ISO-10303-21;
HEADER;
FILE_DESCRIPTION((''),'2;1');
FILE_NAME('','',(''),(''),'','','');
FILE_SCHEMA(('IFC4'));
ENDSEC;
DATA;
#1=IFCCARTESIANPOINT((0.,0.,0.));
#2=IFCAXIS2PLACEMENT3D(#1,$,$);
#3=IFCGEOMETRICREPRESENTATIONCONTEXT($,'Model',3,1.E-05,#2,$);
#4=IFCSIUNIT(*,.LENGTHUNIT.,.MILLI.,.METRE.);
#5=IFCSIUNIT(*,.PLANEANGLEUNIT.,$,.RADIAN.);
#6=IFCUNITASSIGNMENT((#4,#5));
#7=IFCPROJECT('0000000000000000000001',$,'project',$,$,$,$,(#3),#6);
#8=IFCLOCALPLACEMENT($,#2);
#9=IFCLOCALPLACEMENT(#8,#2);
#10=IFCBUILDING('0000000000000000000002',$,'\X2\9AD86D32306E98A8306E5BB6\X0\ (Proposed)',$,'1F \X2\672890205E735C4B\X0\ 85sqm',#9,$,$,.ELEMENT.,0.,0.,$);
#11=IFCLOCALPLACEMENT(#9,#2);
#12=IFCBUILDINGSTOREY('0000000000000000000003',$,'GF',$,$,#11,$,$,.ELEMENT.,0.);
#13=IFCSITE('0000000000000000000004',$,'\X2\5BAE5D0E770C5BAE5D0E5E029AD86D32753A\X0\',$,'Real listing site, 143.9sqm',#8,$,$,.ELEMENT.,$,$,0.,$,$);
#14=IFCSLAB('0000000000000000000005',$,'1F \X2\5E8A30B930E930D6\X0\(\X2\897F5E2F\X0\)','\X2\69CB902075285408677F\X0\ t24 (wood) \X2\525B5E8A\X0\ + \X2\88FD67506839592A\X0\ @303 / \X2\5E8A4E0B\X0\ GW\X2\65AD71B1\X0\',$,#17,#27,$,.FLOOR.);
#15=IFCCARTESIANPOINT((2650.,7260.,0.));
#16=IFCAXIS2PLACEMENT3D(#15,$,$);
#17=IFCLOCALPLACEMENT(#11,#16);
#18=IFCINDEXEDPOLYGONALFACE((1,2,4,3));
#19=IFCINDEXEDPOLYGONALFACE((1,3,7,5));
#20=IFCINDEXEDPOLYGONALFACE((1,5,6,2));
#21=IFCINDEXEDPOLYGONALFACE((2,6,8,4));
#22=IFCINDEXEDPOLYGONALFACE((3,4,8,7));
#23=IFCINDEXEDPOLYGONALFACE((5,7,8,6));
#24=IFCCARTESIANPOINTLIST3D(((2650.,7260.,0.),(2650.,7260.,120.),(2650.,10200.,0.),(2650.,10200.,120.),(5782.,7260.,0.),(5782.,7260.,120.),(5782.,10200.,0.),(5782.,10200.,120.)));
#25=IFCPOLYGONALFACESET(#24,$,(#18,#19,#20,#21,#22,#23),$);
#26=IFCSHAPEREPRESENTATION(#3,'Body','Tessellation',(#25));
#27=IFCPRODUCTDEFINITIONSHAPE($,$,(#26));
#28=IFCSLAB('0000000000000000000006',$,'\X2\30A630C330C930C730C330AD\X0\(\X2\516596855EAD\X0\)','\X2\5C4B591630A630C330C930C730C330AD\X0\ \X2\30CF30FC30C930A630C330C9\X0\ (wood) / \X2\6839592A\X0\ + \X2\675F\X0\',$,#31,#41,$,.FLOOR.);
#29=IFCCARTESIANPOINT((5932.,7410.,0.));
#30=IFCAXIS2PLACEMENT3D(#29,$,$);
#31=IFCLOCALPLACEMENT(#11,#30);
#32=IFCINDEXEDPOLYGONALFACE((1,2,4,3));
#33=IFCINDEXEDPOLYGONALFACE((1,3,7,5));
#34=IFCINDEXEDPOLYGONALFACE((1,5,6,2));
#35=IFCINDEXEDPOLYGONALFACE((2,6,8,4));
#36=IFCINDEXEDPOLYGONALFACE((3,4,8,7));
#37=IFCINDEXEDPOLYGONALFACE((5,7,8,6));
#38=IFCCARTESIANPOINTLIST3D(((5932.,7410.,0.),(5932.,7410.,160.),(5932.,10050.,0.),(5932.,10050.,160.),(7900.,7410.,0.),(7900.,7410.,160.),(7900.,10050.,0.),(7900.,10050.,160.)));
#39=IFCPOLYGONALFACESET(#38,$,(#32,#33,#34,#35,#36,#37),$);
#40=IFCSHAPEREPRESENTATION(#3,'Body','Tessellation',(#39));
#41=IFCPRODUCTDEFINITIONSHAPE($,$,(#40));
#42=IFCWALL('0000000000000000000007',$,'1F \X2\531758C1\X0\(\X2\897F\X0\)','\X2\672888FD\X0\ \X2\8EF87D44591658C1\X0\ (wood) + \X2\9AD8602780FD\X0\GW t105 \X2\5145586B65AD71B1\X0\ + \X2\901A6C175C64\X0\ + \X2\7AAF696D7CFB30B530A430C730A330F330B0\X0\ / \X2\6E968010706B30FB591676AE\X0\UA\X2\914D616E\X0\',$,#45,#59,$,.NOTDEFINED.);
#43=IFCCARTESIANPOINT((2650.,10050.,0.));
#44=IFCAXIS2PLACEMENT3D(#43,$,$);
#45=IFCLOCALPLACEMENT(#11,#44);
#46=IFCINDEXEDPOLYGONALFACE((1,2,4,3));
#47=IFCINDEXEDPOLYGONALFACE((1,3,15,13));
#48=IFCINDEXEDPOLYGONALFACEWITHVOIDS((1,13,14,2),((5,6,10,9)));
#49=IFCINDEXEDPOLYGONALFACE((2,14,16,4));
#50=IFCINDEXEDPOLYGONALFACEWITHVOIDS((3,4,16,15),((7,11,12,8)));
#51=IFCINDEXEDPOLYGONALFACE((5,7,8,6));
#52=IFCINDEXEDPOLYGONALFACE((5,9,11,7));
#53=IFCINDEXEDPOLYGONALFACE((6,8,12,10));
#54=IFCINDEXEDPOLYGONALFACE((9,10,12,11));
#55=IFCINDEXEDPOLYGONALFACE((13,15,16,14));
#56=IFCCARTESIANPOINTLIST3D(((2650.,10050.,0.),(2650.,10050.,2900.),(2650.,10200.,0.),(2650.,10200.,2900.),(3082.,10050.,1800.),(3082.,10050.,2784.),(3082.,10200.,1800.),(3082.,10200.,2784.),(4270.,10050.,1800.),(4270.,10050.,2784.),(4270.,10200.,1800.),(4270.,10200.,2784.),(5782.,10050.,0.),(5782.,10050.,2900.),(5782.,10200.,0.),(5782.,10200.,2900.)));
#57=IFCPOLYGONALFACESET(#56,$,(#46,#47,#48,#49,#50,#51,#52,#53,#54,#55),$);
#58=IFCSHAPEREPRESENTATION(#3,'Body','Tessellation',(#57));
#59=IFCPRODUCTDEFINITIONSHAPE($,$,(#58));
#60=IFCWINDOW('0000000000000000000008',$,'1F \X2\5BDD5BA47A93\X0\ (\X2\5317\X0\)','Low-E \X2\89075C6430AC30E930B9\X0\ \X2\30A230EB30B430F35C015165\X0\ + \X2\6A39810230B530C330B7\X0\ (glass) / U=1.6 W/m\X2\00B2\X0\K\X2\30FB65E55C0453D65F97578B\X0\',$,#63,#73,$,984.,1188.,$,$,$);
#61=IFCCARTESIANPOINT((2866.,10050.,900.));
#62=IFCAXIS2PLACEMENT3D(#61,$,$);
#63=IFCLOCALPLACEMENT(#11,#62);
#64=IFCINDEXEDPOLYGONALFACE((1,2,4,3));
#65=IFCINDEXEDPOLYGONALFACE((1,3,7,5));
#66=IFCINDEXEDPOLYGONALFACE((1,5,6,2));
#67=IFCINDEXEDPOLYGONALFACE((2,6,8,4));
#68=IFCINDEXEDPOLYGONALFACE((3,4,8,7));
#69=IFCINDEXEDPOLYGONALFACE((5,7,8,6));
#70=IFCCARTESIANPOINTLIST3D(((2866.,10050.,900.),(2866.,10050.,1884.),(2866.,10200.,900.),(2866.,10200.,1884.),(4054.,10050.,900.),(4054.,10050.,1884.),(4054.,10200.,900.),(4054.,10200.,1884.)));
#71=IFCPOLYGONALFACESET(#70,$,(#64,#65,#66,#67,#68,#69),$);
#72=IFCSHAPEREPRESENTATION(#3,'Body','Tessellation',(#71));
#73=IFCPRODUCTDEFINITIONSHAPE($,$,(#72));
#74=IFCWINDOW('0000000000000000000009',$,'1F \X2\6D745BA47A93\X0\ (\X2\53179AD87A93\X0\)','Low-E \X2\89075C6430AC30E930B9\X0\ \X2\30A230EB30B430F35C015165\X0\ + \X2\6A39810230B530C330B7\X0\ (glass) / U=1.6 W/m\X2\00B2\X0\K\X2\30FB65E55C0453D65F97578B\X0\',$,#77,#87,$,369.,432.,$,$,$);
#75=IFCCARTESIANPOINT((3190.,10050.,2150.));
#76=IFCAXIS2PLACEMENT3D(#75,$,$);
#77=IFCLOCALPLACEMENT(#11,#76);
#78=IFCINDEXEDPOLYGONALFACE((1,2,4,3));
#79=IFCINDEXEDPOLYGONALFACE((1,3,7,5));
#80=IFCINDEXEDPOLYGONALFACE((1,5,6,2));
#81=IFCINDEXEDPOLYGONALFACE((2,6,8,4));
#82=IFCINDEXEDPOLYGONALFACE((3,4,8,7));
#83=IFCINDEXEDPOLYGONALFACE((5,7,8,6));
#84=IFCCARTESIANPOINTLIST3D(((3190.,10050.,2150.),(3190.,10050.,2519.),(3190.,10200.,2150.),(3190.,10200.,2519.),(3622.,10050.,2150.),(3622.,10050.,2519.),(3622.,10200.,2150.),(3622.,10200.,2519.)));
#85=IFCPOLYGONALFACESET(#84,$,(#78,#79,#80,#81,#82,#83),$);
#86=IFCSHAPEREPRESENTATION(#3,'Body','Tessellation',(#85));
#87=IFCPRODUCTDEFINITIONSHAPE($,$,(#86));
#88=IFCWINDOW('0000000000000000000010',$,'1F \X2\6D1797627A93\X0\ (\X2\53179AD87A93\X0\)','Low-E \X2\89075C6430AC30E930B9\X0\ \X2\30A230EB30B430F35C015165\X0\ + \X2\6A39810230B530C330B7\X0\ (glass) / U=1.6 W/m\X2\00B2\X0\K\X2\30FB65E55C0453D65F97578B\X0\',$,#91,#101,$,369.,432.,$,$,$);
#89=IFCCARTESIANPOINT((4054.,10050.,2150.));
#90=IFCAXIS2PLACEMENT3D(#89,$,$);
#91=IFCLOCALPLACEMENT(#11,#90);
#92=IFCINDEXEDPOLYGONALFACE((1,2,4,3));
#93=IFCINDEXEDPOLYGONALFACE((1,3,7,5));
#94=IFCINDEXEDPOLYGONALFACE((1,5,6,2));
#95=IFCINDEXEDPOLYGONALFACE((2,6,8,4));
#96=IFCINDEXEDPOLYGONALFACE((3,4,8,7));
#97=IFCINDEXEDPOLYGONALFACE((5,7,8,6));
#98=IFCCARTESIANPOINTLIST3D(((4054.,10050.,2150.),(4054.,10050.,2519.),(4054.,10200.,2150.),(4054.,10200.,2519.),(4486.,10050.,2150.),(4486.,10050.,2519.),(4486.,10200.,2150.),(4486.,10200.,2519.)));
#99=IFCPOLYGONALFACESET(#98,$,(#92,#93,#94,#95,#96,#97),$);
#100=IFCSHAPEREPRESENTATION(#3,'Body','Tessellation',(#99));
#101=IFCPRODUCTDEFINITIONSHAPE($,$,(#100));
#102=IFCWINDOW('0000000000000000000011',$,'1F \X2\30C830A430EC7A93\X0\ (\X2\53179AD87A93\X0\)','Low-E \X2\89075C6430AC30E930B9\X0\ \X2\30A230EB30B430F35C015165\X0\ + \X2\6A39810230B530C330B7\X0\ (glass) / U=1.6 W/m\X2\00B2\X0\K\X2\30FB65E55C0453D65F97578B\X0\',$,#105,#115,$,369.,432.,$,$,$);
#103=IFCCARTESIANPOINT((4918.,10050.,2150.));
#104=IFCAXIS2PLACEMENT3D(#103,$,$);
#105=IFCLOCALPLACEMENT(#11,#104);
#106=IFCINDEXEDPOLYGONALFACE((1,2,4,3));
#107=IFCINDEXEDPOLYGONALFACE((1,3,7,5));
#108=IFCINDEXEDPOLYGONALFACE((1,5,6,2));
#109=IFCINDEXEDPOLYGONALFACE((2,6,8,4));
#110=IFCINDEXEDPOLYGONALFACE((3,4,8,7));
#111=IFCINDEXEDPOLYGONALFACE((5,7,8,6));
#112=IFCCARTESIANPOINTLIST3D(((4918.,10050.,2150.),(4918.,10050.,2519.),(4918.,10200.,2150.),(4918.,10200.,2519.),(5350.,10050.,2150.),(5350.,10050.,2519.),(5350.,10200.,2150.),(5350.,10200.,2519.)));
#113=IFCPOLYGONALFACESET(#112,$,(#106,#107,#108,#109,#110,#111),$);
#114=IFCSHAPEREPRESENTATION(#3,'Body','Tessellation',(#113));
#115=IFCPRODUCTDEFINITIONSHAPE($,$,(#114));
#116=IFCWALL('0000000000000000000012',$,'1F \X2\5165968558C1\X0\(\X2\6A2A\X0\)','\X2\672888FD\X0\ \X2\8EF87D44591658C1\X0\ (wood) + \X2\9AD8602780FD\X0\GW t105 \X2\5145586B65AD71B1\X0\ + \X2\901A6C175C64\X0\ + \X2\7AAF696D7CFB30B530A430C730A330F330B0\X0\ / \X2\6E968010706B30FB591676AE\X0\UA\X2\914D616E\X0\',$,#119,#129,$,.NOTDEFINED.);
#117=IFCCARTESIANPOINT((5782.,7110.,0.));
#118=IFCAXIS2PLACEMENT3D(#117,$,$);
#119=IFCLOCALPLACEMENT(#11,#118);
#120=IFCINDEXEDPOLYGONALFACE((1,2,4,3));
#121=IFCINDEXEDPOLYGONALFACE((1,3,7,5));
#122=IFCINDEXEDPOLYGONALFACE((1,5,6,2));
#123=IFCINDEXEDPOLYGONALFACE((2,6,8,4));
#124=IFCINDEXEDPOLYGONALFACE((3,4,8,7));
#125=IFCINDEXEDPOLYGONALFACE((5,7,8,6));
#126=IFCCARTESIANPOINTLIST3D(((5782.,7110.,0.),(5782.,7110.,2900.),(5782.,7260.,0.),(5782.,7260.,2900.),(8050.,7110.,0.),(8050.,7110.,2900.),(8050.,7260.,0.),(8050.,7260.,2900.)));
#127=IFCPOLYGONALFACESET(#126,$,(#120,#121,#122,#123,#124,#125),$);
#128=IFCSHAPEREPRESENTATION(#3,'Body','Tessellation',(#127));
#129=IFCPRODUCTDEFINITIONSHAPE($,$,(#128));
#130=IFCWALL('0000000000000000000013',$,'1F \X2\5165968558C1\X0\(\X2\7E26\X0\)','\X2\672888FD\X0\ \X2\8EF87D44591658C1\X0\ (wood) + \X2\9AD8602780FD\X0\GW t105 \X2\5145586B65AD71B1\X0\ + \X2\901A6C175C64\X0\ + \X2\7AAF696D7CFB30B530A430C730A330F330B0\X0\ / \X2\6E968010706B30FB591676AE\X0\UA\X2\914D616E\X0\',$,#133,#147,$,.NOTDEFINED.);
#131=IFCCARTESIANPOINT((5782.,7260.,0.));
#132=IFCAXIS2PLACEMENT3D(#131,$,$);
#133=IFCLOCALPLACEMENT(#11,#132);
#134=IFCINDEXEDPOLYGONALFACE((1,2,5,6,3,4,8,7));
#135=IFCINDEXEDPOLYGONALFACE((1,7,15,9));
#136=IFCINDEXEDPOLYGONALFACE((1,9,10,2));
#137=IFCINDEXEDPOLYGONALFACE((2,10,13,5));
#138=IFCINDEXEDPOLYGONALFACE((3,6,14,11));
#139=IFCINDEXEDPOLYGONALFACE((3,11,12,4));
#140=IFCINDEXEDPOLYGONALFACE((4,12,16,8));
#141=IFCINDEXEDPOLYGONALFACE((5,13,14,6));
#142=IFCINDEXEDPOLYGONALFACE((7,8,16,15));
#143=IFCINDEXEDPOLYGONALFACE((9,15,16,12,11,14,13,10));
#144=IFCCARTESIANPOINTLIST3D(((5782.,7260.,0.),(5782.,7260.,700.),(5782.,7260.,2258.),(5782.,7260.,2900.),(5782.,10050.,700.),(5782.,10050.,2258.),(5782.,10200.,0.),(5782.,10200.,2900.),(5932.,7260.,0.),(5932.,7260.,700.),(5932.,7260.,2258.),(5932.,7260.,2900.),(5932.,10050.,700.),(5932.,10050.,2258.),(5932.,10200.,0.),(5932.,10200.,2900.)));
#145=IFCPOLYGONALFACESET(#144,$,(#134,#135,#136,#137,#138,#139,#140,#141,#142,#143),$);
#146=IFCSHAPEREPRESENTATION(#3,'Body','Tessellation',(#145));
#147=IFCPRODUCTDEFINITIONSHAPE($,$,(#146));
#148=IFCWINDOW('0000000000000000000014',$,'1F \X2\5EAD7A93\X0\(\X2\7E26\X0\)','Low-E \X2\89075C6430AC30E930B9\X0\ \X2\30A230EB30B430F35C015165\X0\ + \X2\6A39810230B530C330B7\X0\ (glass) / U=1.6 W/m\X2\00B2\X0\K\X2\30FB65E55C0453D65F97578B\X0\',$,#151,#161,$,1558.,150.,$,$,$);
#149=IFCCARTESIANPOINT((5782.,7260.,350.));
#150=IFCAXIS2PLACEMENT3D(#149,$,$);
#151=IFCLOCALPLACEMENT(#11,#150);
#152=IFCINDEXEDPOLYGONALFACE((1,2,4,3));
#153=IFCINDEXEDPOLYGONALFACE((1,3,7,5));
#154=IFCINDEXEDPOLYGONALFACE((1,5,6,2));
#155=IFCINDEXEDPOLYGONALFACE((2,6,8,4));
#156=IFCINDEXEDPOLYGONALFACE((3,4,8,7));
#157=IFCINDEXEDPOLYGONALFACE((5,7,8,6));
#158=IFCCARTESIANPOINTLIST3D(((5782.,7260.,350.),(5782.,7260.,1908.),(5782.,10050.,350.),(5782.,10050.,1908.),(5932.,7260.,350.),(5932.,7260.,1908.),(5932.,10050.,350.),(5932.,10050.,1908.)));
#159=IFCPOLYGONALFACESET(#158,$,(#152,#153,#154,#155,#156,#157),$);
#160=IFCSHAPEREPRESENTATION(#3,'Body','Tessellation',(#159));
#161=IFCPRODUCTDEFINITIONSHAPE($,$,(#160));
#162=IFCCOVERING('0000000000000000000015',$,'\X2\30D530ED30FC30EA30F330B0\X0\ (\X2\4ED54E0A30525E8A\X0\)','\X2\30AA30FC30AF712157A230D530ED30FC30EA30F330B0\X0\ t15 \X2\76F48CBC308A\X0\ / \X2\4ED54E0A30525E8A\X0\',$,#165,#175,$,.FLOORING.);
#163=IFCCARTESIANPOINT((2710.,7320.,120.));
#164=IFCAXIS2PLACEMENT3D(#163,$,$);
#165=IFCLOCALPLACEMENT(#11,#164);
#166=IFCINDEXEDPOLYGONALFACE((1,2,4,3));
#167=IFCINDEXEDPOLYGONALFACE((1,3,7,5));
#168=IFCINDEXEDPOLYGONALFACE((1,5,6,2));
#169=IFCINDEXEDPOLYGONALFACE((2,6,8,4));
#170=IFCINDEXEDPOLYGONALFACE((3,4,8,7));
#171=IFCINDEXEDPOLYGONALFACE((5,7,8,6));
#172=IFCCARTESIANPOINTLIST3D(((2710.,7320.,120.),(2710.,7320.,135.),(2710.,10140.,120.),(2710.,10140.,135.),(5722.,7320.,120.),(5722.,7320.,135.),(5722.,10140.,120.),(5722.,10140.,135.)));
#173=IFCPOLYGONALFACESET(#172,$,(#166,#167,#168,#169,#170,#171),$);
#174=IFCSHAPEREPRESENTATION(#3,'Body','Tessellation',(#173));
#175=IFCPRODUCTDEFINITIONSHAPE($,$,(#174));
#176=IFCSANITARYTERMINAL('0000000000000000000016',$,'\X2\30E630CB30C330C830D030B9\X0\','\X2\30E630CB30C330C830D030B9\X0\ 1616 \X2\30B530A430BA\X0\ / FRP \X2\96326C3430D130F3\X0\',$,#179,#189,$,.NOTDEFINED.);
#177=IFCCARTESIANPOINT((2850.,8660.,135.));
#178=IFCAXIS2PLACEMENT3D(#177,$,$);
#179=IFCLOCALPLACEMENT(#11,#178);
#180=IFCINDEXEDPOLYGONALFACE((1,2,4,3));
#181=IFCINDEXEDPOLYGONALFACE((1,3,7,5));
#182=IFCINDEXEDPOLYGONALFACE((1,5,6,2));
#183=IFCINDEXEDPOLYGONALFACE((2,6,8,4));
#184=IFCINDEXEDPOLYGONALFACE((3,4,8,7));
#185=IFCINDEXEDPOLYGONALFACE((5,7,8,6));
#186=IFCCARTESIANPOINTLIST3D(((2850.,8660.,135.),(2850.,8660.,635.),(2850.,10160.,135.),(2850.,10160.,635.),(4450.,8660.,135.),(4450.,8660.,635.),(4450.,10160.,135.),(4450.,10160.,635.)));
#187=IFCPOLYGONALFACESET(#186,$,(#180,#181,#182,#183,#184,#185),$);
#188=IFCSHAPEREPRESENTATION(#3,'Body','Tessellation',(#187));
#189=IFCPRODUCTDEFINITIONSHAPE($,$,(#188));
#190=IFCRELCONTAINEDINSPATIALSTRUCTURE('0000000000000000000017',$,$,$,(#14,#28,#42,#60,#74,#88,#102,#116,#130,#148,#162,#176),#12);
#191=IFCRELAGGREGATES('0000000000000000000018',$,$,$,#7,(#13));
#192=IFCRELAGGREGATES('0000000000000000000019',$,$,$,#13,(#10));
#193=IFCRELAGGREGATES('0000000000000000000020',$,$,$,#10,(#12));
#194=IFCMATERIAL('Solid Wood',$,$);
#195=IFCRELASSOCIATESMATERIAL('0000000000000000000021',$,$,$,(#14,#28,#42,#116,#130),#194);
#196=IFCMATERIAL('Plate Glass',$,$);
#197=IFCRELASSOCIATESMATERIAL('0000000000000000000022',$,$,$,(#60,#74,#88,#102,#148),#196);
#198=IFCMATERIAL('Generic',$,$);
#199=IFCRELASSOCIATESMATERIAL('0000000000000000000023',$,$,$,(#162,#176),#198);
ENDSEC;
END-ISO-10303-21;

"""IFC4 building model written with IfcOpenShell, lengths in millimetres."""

from ifc_helpers import new_model, si_unit, frame, frame_2d, origin, place, context, project, spatial, rectangle, extrude, material, element, fill, save


model = new_model("IFC4")

# Units and contexts
model_context = context("Model", 3, precision=1e-05, world=origin())
ifc_project = project(units=[si_unit("LENGTHUNIT", "METRE", prefix="MILLI"), si_unit("PLANEANGLEUNIT", "RADIAN")], contexts=[model_context])

# Site, building, storey
site_placement = place(None, origin())
site = spatial("IfcSite", under=ifc_project, at=site_placement, Name="宮崎県宮崎市高洲町", ObjectType="Real listing site, 143.9sqm", CompositionType="ELEMENT", RefElevation=0.0)
building_placement = place(site_placement, origin())
building = spatial("IfcBuilding", under=site, at=building_placement, Name="高洲の風の家 (Proposed)", ObjectType="1F 木造平屋 85sqm", CompositionType="ELEMENT", ElevationOfRefHeight=0.0, ElevationOfTerrain=0.0)
storey_placement = place(building_placement, origin())
storey = spatial("IfcBuildingStorey", under=building, at=storey_placement, Name="GF", CompositionType="ELEMENT", Elevation=0.0)

# Slabs
ifc_material_1 = material(Name="Solid Wood")
slab_1_placement = place(storey_placement, frame((2650.0, 7260.0, 0.0)))
element("IfcSlab", 1, at=slab_1_placement, inside=storey, material=ifc_material_1, Name="1F 床スラブ(西帯)", Description="構造用合板 t24 (wood) 剛床 + 製材根太 @303 / 床下 GW断熱", PredefinedType="FLOOR", context=model_context, shape_type="SweptSolid", body=[
    extrude(rectangle(XDim=3132.0, YDim=2940.0, at=frame_2d((1566.0, 1470.0))), frame((2650.0, 7260.0, 0.0)), (0.0, 0.0, 1.0), 120.0),
])
slab_2_placement = place(storey_placement, frame((5932.0, 7410.0, 0.0)))
element("IfcSlab", 2, at=slab_2_placement, inside=storey, material=ifc_material_1, Name="ウッドデッキ(入隅庭)", Description="屋外ウッドデッキ ハードウッド (wood) / 根太 + 束", PredefinedType="FLOOR", context=model_context, shape_type="SweptSolid", body=[
    extrude(rectangle(XDim=1968.0, YDim=2640.0, at=frame_2d((984.0, 1320.0))), frame((5932.0, 7410.0, 0.0)), (0.0, 0.0, 1.0), 160.0),
])

# Wall, openings, windows
wall_1_placement = place(storey_placement, frame((2650.0, 10050.0, 0.0)))
wall_1 = element("IfcWall", 3, at=wall_1_placement, inside=storey, material=ifc_material_1, Name="1F 北壁(西)", Description="木製 軸組外壁 (wood) + 高性能GW t105 充填断熱 + 通気層 + 窯業系サイディング / 準耐火・外皮UA配慮", PredefinedType="NOTDEFINED", context=model_context, shape_type="SweptSolid", body=[
    extrude(rectangle(XDim=3132.0, YDim=150.0, at=frame_2d((1566.0, 75.0))), frame((2650.0, 10050.0, 0.0)), (0.0, 0.0, 1.0), 2900.0),
])
opening_1_placement = place(storey_placement, frame((2866.0, 10050.0, 900.0)))
opening_1 = element("IfcOpeningElement", 4, at=opening_1_placement, cuts=wall_1, PredefinedType="NOTDEFINED", context=model_context, shape_type="SweptSolid", body=[
    extrude(rectangle(XDim=1188.0, YDim=150.0, at=frame_2d((594.0, 75.0))), frame((2866.0, 10050.0, 900.0)), (0.0, 0.0, 1.0), 984.0),
])
opening_2_placement = place(storey_placement, frame((3190.0, 10050.0, 2150.0)))
opening_2 = element("IfcOpeningElement", 5, at=opening_2_placement, cuts=wall_1, PredefinedType="NOTDEFINED", context=model_context, shape_type="SweptSolid", body=[
    extrude(rectangle(XDim=432.0, YDim=150.0, at=frame_2d((216.0, 75.0))), frame((3190.0, 10050.0, 2150.0)), (0.0, 0.0, 1.0), 369.0),
])
opening_3_placement = place(storey_placement, frame((4054.0, 10050.0, 2150.0)))
opening_3 = element("IfcOpeningElement", 6, at=opening_3_placement, cuts=wall_1, PredefinedType="NOTDEFINED", context=model_context, shape_type="SweptSolid", body=[
    extrude(rectangle(XDim=432.0, YDim=150.0, at=frame_2d((216.0, 75.0))), frame((4054.0, 10050.0, 2150.0)), (0.0, 0.0, 1.0), 369.0),
])
opening_4_placement = place(storey_placement, frame((4918.0, 10050.0, 2150.0)))
opening_4 = element("IfcOpeningElement", 7, at=opening_4_placement, cuts=wall_1, PredefinedType="NOTDEFINED", context=model_context, shape_type="SweptSolid", body=[
    extrude(rectangle(XDim=432.0, YDim=150.0, at=frame_2d((216.0, 75.0))), frame((4918.0, 10050.0, 2150.0)), (0.0, 0.0, 1.0), 369.0),
])
ifc_material_2 = material(Name="Plate Glass")
window_1_placement = place(storey_placement, frame((2866.0, 10050.0, 900.0)))
window_1 = element("IfcWindow", 8, at=window_1_placement, inside=storey, material=ifc_material_2, Name="1F 寝室窓 (北)", Description="Low-E 複層ガラス アルゴン封入 + 樹脂サッシ (glass) / U=1.6 W/m²K・日射取得型", OverallHeight=984.0, OverallWidth=1188.0, context=model_context, shape_type="SweptSolid", body=[
    extrude(rectangle(XDim=1188.0, YDim=150.0, at=frame_2d((594.0, 75.0))), frame((2866.0, 10050.0, 900.0)), (0.0, 0.0, 1.0), 984.0),
])
fill(opening_1, window_1)
window_2_placement = place(storey_placement, frame((3190.0, 10050.0, 2150.0)))
window_2 = element("IfcWindow", 9, at=window_2_placement, inside=storey, material=ifc_material_2, Name="1F 浴室窓 (北高窓)", Description="Low-E 複層ガラス アルゴン封入 + 樹脂サッシ (glass) / U=1.6 W/m²K・日射取得型", OverallHeight=369.0, OverallWidth=432.0, context=model_context, shape_type="SweptSolid", body=[
    extrude(rectangle(XDim=432.0, YDim=150.0, at=frame_2d((216.0, 75.0))), frame((3190.0, 10050.0, 2150.0)), (0.0, 0.0, 1.0), 369.0),
])
fill(opening_2, window_2)
window_3_placement = place(storey_placement, frame((4054.0, 10050.0, 2150.0)))
window_3 = element("IfcWindow", 10, at=window_3_placement, inside=storey, material=ifc_material_2, Name="1F 洗面窓 (北高窓)", Description="Low-E 複層ガラス アルゴン封入 + 樹脂サッシ (glass) / U=1.6 W/m²K・日射取得型", OverallHeight=369.0, OverallWidth=432.0, context=model_context, shape_type="SweptSolid", body=[
    extrude(rectangle(XDim=432.0, YDim=150.0, at=frame_2d((216.0, 75.0))), frame((4054.0, 10050.0, 2150.0)), (0.0, 0.0, 1.0), 369.0),
])
fill(opening_3, window_3)
window_4_placement = place(storey_placement, frame((4918.0, 10050.0, 2150.0)))
window_4 = element("IfcWindow", 11, at=window_4_placement, inside=storey, material=ifc_material_2, Name="1F トイレ窓 (北高窓)", Description="Low-E 複層ガラス アルゴン封入 + 樹脂サッシ (glass) / U=1.6 W/m²K・日射取得型", OverallHeight=369.0, OverallWidth=432.0, context=model_context, shape_type="SweptSolid", body=[
    extrude(rectangle(XDim=432.0, YDim=150.0, at=frame_2d((216.0, 75.0))), frame((4918.0, 10050.0, 2150.0)), (0.0, 0.0, 1.0), 369.0),
])
fill(opening_4, window_4)

# Wall
wall_2_placement = place(storey_placement, frame((5782.0, 7110.0, 0.0)))
element("IfcWall", 12, at=wall_2_placement, inside=storey, material=ifc_material_1, Name="1F 入隅壁(横)", Description="木製 軸組外壁 (wood) + 高性能GW t105 充填断熱 + 通気層 + 窯業系サイディング / 準耐火・外皮UA配慮", PredefinedType="NOTDEFINED", context=model_context, shape_type="SweptSolid", body=[
    extrude(rectangle(XDim=2268.0, YDim=150.0, at=frame_2d((1134.0, 75.0))), frame((5782.0, 7110.0, 0.0)), (0.0, 0.0, 1.0), 2900.0),
])

# Wall, opening, window
wall_3_placement = place(storey_placement, frame((5782.0, 7260.0, 0.0)))
wall_3 = element("IfcWall", 13, at=wall_3_placement, inside=storey, material=ifc_material_1, Name="1F 入隅壁(縦)", Description="木製 軸組外壁 (wood) + 高性能GW t105 充填断熱 + 通気層 + 窯業系サイディング / 準耐火・外皮UA配慮", PredefinedType="NOTDEFINED", context=model_context, shape_type="SweptSolid", body=[
    extrude(rectangle(XDim=150.0, YDim=2940.0, at=frame_2d((75.0, 1470.0))), frame((5782.0, 7260.0, 0.0)), (0.0, 0.0, 1.0), 2900.0),
])
opening_5_placement = place(storey_placement, frame((5782.0, 7260.0, 350.0)))
opening_5 = element("IfcOpeningElement", 14, at=opening_5_placement, cuts=wall_3, PredefinedType="NOTDEFINED", context=model_context, shape_type="SweptSolid", body=[
    extrude(rectangle(XDim=150.0, YDim=2790.0, at=frame_2d((75.0, 1395.0))), frame((5782.0, 7260.0, 350.0)), (0.0, 0.0, 1.0), 1558.0),
])
window_5_placement = place(storey_placement, frame((5782.0, 7260.0, 350.0)))
window_5 = element("IfcWindow", 15, at=window_5_placement, inside=storey, material=ifc_material_2, Name="1F 庭窓(縦)", Description="Low-E 複層ガラス アルゴン封入 + 樹脂サッシ (glass) / U=1.6 W/m²K・日射取得型", OverallHeight=1558.0, OverallWidth=150.0, context=model_context, shape_type="SweptSolid", body=[
    extrude(rectangle(XDim=150.0, YDim=2790.0, at=frame_2d((75.0, 1395.0))), frame((5782.0, 7260.0, 350.0)), (0.0, 0.0, 1.0), 1558.0),
])
fill(opening_5, window_5)

# Covering
ifc_material_3 = material(Name="Generic")
covering_placement = place(storey_placement, frame((2710.0, 7320.0, 120.0)))
element("IfcCovering", 16, at=covering_placement, inside=storey, material=ifc_material_3, Name="フローリング (仕上げ床)", Description="オーク無垢フローリング t15 直貼り / 仕上げ床", PredefinedType="FLOORING", context=model_context, shape_type="SweptSolid", body=[
    extrude(rectangle(XDim=3012.0, YDim=2820.0, at=frame_2d((1506.0, 1410.0))), frame((2710.0, 7320.0, 120.0)), (0.0, 0.0, 1.0), 15.0),
])

# Sanitary terminal
sanitary_terminal_1_placement = place(storey_placement, frame((2850.0, 8660.0, 135.0)))
element("IfcSanitaryTerminal", 17, at=sanitary_terminal_1_placement, inside=storey, material=ifc_material_3, Name="ユニットバス", Description="ユニットバス 1616 サイズ / FRP 防水パン", PredefinedType="NOTDEFINED", context=model_context, shape_type="SweptSolid", body=[
    extrude(rectangle(XDim=1600.0, YDim=1500.0, at=frame_2d((800.0, 750.0))), frame((2850.0, 8660.0, 135.0)), (0.0, 0.0, 1.0), 500.0),
])

save(model, "model.ifc")
